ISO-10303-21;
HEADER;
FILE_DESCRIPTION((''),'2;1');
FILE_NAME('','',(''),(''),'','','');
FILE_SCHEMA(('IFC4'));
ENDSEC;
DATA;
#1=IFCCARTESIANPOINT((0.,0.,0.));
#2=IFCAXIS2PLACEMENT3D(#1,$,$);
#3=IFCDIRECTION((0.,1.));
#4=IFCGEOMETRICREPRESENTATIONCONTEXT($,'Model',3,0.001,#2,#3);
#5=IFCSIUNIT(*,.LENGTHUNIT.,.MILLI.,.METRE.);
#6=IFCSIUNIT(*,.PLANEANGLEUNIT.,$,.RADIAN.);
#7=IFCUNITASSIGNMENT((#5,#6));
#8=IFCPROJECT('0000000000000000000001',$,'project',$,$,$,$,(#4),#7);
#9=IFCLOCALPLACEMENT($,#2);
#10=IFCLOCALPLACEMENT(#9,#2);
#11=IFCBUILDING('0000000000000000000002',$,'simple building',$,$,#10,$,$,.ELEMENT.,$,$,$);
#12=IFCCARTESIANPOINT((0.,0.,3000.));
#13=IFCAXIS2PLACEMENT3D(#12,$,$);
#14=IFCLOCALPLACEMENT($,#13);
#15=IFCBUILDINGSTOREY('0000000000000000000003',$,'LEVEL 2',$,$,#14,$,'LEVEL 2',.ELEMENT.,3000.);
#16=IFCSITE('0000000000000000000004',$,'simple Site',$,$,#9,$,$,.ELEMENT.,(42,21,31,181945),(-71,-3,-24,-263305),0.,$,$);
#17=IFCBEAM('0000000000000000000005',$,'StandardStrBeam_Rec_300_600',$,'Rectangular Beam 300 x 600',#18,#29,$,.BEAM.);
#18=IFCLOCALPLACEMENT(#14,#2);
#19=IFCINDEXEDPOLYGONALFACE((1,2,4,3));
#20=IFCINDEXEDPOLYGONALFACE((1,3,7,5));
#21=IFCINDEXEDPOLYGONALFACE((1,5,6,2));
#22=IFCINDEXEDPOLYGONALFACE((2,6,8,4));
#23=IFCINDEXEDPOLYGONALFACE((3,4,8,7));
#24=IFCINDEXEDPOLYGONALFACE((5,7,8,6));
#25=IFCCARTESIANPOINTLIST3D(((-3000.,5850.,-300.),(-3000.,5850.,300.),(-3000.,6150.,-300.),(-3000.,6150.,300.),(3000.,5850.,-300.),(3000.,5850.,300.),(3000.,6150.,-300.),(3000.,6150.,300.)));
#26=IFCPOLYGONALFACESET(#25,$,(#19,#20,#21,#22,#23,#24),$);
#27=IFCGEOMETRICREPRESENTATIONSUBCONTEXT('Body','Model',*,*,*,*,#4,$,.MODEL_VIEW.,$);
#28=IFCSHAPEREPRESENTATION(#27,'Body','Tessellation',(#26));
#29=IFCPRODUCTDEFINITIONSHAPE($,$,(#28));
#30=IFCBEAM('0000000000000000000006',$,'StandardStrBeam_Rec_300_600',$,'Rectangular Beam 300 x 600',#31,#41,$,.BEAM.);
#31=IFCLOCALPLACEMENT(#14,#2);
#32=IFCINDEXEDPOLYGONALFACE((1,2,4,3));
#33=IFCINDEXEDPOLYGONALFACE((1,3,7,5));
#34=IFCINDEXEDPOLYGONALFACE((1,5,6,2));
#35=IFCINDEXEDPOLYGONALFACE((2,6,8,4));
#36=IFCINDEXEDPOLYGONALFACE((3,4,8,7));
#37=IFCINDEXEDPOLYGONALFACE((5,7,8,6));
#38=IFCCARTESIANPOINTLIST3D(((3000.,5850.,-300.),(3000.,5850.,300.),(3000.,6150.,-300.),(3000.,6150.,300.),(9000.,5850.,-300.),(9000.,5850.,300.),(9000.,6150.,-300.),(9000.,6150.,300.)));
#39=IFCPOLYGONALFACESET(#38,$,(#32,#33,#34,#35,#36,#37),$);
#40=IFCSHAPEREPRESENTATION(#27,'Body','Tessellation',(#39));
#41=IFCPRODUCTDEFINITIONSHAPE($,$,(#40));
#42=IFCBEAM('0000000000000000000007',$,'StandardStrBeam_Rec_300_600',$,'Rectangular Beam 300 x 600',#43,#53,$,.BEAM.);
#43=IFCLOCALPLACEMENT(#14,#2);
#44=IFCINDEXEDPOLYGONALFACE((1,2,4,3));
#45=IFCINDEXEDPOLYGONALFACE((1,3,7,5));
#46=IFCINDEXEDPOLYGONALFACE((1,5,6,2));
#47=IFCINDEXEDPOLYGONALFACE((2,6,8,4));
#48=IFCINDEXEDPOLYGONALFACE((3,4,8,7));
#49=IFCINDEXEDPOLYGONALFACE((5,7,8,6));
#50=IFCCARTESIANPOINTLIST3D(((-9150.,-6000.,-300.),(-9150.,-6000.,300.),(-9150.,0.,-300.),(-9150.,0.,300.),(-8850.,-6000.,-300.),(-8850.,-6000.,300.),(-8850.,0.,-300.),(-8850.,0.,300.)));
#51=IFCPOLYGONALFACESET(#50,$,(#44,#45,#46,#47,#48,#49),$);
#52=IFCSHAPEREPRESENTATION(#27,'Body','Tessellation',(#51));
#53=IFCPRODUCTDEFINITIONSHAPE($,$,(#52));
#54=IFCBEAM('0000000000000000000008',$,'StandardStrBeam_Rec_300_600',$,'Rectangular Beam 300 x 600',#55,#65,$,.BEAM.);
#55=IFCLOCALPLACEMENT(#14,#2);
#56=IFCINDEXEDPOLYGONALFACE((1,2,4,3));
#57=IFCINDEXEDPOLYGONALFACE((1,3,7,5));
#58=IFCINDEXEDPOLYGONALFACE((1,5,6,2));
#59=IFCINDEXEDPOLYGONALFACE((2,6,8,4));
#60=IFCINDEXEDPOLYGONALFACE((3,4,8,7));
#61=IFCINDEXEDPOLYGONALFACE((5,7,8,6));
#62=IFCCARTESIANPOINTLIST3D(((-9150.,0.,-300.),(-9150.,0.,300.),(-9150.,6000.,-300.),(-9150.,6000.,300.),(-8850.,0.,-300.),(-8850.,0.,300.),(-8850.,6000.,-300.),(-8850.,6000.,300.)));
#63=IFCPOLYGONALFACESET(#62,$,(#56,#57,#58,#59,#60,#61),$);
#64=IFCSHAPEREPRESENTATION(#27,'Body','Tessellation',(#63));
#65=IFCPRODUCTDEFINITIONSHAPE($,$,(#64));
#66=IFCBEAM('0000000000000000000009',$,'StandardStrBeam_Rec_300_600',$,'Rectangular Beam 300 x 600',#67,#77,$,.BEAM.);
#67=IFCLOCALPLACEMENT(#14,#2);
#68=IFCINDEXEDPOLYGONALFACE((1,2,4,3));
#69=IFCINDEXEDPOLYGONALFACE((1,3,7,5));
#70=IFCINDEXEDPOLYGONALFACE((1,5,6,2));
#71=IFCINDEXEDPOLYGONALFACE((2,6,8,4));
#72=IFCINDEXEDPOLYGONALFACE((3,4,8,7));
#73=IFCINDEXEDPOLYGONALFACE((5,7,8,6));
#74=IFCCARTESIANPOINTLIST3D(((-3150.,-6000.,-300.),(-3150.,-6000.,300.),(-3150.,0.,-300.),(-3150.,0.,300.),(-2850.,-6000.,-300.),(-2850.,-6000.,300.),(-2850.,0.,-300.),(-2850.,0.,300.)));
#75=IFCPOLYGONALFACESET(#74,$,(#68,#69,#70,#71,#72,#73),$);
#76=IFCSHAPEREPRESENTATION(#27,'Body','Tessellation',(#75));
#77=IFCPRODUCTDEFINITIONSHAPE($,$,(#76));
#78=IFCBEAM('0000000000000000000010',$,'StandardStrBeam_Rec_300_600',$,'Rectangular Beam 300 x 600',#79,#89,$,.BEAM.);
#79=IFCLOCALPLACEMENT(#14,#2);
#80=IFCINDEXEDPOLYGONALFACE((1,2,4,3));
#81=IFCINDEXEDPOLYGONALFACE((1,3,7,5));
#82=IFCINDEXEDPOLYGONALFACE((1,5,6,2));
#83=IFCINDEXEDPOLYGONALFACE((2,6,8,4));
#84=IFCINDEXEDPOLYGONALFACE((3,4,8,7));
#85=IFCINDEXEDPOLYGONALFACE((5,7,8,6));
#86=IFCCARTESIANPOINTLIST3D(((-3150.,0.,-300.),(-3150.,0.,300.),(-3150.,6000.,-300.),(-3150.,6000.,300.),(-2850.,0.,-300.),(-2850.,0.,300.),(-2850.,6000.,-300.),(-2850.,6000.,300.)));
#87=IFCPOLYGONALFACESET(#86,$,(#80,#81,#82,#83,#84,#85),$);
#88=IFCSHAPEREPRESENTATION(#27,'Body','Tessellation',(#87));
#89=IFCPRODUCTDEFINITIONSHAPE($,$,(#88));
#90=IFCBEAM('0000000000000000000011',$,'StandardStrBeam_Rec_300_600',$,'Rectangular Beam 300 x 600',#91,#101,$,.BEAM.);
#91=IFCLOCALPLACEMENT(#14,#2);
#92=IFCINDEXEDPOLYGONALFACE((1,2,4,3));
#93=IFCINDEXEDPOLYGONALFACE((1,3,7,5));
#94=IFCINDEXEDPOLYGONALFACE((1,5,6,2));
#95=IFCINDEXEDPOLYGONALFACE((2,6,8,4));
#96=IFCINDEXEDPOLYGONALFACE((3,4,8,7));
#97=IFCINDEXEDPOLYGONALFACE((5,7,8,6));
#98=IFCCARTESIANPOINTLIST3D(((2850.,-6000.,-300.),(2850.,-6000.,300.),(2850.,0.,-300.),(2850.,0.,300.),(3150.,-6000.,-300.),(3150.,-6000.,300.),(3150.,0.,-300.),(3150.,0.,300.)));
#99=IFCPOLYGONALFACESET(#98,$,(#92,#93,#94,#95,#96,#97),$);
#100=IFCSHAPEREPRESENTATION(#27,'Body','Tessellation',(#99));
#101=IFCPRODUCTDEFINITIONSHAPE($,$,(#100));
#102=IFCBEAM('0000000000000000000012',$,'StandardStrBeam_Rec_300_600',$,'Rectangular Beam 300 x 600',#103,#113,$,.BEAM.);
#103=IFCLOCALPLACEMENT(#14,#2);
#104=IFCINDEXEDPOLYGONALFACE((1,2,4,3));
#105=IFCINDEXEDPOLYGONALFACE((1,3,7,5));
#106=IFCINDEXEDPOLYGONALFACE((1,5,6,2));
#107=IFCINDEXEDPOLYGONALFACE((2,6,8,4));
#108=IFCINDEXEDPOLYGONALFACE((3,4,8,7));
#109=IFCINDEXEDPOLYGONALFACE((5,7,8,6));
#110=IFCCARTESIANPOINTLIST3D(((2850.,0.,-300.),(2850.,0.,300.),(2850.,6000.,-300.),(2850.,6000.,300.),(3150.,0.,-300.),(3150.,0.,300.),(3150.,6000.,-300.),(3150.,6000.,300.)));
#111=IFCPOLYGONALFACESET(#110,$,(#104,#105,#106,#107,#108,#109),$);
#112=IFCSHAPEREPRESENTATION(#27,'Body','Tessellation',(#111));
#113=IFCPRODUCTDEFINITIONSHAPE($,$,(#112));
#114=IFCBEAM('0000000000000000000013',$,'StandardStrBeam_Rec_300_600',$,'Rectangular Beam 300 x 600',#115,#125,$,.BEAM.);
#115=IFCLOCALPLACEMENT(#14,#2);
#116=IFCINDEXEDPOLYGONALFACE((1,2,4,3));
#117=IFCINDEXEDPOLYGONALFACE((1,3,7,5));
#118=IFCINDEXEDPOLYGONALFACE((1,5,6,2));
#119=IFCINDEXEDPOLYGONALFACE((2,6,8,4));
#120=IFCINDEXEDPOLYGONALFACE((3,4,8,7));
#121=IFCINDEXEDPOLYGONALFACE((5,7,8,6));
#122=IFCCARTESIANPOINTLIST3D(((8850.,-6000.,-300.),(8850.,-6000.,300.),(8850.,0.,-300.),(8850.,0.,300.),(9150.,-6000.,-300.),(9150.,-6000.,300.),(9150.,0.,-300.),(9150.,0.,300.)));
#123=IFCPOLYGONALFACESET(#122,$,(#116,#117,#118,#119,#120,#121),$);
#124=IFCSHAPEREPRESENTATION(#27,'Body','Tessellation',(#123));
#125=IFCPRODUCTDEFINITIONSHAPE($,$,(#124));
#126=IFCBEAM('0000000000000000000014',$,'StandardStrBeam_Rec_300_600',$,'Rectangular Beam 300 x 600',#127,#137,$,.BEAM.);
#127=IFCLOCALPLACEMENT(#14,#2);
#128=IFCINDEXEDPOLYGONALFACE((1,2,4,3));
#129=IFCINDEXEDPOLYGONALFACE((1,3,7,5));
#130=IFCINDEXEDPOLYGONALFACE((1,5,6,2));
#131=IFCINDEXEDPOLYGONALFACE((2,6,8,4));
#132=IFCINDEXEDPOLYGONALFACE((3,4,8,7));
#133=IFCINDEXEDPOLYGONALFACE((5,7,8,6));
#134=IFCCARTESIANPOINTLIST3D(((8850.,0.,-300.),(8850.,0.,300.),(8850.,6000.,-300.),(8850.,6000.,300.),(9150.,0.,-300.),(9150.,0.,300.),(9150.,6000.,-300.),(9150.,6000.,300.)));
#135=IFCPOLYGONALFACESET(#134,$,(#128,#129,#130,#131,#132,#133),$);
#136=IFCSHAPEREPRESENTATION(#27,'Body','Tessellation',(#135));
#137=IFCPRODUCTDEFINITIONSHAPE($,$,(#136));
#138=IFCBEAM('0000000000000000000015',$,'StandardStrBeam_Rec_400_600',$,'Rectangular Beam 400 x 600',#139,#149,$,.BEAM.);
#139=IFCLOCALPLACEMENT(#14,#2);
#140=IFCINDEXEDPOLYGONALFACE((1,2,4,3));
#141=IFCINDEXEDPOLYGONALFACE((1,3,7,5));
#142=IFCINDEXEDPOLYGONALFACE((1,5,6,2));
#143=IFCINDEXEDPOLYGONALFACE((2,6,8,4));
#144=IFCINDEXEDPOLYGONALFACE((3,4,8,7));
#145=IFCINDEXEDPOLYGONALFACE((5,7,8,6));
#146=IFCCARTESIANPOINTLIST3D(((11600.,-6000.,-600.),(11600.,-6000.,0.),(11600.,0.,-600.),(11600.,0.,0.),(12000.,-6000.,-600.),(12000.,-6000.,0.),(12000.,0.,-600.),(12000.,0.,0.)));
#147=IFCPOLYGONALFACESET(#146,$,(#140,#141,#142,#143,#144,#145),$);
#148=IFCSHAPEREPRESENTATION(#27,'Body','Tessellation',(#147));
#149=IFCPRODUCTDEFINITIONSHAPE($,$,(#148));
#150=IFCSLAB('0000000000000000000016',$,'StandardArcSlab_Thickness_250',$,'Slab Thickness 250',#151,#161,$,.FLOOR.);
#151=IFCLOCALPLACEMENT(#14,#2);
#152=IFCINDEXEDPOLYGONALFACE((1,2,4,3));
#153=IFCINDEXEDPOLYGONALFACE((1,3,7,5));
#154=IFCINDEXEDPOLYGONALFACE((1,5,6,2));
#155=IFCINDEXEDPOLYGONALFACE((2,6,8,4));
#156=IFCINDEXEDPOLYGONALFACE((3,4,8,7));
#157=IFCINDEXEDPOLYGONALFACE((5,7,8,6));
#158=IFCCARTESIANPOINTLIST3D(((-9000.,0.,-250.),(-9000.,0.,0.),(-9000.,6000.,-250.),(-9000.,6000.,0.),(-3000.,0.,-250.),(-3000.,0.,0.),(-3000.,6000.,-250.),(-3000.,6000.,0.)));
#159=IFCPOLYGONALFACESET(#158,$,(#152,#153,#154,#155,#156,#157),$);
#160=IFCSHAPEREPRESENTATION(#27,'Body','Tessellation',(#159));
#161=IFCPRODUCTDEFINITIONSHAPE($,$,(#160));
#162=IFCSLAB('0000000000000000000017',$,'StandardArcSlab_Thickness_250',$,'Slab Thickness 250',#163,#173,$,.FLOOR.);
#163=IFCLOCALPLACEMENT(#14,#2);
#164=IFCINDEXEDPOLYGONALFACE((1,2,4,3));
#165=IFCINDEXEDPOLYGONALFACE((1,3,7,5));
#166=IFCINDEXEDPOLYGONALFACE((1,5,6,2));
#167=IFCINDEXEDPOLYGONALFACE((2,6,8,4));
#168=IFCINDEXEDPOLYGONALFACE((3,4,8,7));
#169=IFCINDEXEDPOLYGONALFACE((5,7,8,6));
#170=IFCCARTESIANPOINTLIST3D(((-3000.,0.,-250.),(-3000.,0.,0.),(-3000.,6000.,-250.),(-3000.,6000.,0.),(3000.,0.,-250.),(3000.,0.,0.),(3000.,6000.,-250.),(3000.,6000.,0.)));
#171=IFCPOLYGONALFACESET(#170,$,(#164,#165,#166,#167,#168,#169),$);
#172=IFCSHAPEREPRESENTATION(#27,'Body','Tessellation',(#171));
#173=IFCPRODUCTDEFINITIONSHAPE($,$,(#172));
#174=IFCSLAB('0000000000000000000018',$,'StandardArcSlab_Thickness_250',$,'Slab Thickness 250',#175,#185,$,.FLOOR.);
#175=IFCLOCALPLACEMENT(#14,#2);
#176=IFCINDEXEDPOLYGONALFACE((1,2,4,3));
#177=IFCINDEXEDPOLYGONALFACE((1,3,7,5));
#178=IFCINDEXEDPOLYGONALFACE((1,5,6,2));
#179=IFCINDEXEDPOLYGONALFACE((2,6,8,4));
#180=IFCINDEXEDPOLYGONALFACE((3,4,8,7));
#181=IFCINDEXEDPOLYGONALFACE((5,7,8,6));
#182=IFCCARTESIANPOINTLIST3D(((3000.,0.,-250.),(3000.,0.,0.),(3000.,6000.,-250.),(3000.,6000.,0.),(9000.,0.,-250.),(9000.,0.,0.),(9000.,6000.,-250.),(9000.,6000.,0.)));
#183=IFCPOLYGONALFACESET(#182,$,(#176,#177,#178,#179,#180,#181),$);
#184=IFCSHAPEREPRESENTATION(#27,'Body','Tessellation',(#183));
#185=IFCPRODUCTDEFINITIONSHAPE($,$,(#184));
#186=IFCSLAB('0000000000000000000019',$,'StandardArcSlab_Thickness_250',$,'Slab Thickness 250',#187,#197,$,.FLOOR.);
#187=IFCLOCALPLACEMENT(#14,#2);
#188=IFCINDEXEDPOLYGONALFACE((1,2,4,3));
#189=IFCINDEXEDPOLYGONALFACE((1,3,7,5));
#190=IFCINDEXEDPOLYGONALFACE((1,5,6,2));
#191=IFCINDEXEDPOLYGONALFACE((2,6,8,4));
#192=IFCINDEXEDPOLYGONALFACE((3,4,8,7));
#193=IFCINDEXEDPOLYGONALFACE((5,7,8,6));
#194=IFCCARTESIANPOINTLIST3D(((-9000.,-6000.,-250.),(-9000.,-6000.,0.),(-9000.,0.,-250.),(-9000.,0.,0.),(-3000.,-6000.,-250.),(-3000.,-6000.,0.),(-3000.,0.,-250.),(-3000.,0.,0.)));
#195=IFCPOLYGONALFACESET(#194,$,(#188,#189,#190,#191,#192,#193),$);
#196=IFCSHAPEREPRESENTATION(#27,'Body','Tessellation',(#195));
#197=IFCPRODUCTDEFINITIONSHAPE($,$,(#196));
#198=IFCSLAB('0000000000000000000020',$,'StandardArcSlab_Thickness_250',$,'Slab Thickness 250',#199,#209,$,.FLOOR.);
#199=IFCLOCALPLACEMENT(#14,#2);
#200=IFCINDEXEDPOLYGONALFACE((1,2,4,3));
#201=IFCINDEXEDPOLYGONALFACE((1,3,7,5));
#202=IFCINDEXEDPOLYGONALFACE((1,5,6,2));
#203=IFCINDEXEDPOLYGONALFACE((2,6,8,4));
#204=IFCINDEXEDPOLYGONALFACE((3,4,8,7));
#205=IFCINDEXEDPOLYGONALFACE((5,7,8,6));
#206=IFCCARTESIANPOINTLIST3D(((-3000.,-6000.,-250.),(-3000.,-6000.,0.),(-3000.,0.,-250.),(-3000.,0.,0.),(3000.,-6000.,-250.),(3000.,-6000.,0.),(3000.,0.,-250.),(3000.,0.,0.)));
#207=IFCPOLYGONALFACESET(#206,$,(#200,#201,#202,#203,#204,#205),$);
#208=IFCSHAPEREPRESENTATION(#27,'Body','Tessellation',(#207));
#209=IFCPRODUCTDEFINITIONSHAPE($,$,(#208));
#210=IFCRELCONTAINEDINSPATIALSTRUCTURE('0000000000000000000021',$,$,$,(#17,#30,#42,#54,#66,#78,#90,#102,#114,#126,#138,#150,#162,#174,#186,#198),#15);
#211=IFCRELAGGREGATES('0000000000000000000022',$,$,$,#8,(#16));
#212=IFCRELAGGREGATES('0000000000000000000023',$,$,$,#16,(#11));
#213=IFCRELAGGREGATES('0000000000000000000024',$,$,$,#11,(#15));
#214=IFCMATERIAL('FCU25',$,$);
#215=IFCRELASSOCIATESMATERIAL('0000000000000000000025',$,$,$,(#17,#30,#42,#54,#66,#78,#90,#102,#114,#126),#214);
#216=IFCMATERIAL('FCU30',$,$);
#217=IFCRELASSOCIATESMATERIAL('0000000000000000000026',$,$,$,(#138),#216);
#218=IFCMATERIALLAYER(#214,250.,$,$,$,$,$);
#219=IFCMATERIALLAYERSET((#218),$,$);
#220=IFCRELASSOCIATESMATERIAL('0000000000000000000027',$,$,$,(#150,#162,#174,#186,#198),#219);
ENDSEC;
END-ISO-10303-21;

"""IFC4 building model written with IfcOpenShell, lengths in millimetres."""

from ifc_helpers import new_model, si_unit, direction, frame, origin, origin_with_axes, origin_2d_with_axis, place, context, subcontext, project, spatial, polyline, rectangle, outline, extrude, material, layer, layer_set, layer_usage, material_profile, profile_set, profile_usage, element, save


model = new_model("IFC4")

# Units and contexts
model_context = context("Model", 3, precision=0.001, world=origin(), true_north=direction((0.0, 1.0)))
body_context = subcontext(model_context, "Body", "Model", "MODEL_VIEW")
ifc_project = project(units=[si_unit("LENGTHUNIT", "METRE", prefix="MILLI"), si_unit("PLANEANGLEUNIT", "RADIAN")], contexts=[model_context])

# Site, building, storey
site_placement = place(None, origin())
site = spatial("IfcSite", under=ifc_project, at=site_placement, Name="simple Site", CompositionType="ELEMENT", RefLatitude=(42, 21, 31, 181945), RefLongitude=(-71, -3, -24, -263305), RefElevation=0.0)
building_placement = place(site_placement, origin())
building = spatial("IfcBuilding", under=site, at=building_placement, Name="simple building", CompositionType="ELEMENT")
storey_placement = place(None, frame((0.0, 0.0, 3000.0)))
storey = spatial("IfcBuildingStorey", under=building, at=storey_placement, Name="LEVEL 2", LongName="LEVEL 2", CompositionType="ELEMENT", Elevation=3000.0)

# Shared definitions
ifc_material_1 = material(Name="FCU30")
ifc_material_profile_1 = material_profile(ifc_material_1, rectangle(XDim=400.0, YDim=600.0, at=origin_2d_with_axis()))
ifc_profile_set_1 = profile_set([ifc_material_profile_1])

# Beams
ifc_material_2 = material(Name="FCU25")
ifc_material_profile_2 = material_profile(ifc_material_2, rectangle(XDim=300.0, YDim=600.0, at=origin_2d_with_axis()))
ifc_profile_set_2 = profile_set([ifc_material_profile_2])
ifc_profile_usage_1 = profile_usage(ifc_profile_set_2, cardinal=10)
for number, where, z_axis, x_axis, name in (
    (1, (-3000.0, 6000.0, 3000.0), (1.0, 0.0, 0.0), (0.0, -1.0, 0.0), "StandardStrBeam_Rec_300_600"),
    (2, (3000.0, 6000.0, 3000.0), (1.0, 0.0, 0.0), (0.0, -1.0, 0.0), "StandardStrBeam_Rec_300_600"),
    (3, (-9000.0, -6000.0, 3000.0), (0.0, 1.0, 0.0), (1.0, 0.0, 0.0), "StandardStrBeam_Rec_300_600"),
    (4, (-9000.0, 0.0, 3000.0), (0.0, 1.0, 0.0), (1.0, 0.0, 0.0), "StandardStrBeam_Rec_300_600"),
    (5, (-3000.0, -6000.0, 3000.0), (0.0, 1.0, 0.0), (1.0, 0.0, 0.0), "StandardStrBeam_Rec_300_600"),
    (6, (-3000.0, 0.0, 3000.0), (0.0, 1.0, 0.0), (1.0, 0.0, 0.0), "StandardStrBeam_Rec_300_600"),
    (7, (3000.0, -6000.0, 3000.0), (0.0, 1.0, 0.0), (1.0, 0.0, 0.0), "StandardStrBeam_Rec_300_600"),
    (8, (3000.0, 0.0, 3000.0), (0.0, 1.0, 0.0), (1.0, 0.0, 0.0), "StandardStrBeam_Rec_300_600"),
    (9, (9000.0, -6000.0, 3000.0), (0.0, 1.0, 0.0), (1.0, 0.0, 0.0), "StandardStrBeam_Rec_300_600"),
    (10, (9000.0, 0.0, 3000.0), (0.0, 1.0, 0.0), (1.0, 0.0, 0.0), "StandardStrBeam_Rec_300_600"),
):
    element("IfcBeam", number, at=place(None, frame(where, z_axis=z_axis, x_axis=x_axis)), inside=storey, material=ifc_profile_usage_1, Name=name, ObjectType="Rectangular Beam 300 x 600", PredefinedType="BEAM", context=body_context, shape_type="SweptSolid", body=[
        extrude(rectangle(XDim=300.0, YDim=600.0, at=origin_2d_with_axis()), origin_with_axes(), (0.0, 0.0, 1.0), 6000.0),
    ])
ifc_profile_usage_2 = profile_usage(ifc_profile_set_1, cardinal=9)
beam_placement = place(None, frame((11800.0, -6000.0, 2700.0), z_axis=(0.0, 1.0, 0.0), x_axis=(1.0, 0.0, 0.0)))
element("IfcBeam", 11, at=beam_placement, inside=storey, material=ifc_profile_usage_2, Name="StandardStrBeam_Rec_400_600", ObjectType="Rectangular Beam 400 x 600", PredefinedType="BEAM", context=body_context, shape_type="SweptSolid", body=[
    extrude(rectangle(XDim=400.0, YDim=600.0, at=origin_2d_with_axis()), origin_with_axes(), (0.0, 0.0, 1.0), 6000.0),
])

# Slabs
ifc_layer = layer(ifc_material_2, 250.0)
ifc_layer_set = layer_set([ifc_layer])
ifc_layer_usage = layer_usage(ifc_layer_set, "AXIS3", "POSITIVE", -250.0)
for number, where, z_axis, x_axis, name in (
    (12, (-9000.0, 0.0, 2750.0), (0.0, 0.0, 1.0), (1.0, 0.0, 0.0), "StandardArcSlab_Thickness_250"),
    (13, (-3000.0, 0.0, 2750.0), (0.0, 0.0, 1.0), (1.0, 0.0, 0.0), "StandardArcSlab_Thickness_250"),
    (14, (3000.0, 0.0, 2750.0), (0.0, 0.0, 1.0), (1.0, 0.0, 0.0), "StandardArcSlab_Thickness_250"),
    (15, (-9000.0, -6000.0, 2750.0), (0.0, 0.0, 1.0), (1.0, 0.0, 0.0), "StandardArcSlab_Thickness_250"),
    (16, (-3000.0, -6000.0, 2750.0), (0.0, 0.0, 1.0), (1.0, 0.0, 0.0), "StandardArcSlab_Thickness_250"),
):
    element("IfcSlab", number, at=place(None, frame(where, z_axis=z_axis, x_axis=x_axis)), inside=storey, material=ifc_layer_usage, Name=name, ObjectType="Slab Thickness 250", PredefinedType="FLOOR", context=body_context, shape_type="SweptSolid", body=[
        extrude(outline(polyline([(0.0, 0.0), (6000.0, 0.0), (6000.0, 6000.0), (0.0, 6000.0), (0.0, 0.0)])), origin_with_axes(), (0.0, 0.0, 1.0), 250.0),
    ])

save(model, "model.ifc")
